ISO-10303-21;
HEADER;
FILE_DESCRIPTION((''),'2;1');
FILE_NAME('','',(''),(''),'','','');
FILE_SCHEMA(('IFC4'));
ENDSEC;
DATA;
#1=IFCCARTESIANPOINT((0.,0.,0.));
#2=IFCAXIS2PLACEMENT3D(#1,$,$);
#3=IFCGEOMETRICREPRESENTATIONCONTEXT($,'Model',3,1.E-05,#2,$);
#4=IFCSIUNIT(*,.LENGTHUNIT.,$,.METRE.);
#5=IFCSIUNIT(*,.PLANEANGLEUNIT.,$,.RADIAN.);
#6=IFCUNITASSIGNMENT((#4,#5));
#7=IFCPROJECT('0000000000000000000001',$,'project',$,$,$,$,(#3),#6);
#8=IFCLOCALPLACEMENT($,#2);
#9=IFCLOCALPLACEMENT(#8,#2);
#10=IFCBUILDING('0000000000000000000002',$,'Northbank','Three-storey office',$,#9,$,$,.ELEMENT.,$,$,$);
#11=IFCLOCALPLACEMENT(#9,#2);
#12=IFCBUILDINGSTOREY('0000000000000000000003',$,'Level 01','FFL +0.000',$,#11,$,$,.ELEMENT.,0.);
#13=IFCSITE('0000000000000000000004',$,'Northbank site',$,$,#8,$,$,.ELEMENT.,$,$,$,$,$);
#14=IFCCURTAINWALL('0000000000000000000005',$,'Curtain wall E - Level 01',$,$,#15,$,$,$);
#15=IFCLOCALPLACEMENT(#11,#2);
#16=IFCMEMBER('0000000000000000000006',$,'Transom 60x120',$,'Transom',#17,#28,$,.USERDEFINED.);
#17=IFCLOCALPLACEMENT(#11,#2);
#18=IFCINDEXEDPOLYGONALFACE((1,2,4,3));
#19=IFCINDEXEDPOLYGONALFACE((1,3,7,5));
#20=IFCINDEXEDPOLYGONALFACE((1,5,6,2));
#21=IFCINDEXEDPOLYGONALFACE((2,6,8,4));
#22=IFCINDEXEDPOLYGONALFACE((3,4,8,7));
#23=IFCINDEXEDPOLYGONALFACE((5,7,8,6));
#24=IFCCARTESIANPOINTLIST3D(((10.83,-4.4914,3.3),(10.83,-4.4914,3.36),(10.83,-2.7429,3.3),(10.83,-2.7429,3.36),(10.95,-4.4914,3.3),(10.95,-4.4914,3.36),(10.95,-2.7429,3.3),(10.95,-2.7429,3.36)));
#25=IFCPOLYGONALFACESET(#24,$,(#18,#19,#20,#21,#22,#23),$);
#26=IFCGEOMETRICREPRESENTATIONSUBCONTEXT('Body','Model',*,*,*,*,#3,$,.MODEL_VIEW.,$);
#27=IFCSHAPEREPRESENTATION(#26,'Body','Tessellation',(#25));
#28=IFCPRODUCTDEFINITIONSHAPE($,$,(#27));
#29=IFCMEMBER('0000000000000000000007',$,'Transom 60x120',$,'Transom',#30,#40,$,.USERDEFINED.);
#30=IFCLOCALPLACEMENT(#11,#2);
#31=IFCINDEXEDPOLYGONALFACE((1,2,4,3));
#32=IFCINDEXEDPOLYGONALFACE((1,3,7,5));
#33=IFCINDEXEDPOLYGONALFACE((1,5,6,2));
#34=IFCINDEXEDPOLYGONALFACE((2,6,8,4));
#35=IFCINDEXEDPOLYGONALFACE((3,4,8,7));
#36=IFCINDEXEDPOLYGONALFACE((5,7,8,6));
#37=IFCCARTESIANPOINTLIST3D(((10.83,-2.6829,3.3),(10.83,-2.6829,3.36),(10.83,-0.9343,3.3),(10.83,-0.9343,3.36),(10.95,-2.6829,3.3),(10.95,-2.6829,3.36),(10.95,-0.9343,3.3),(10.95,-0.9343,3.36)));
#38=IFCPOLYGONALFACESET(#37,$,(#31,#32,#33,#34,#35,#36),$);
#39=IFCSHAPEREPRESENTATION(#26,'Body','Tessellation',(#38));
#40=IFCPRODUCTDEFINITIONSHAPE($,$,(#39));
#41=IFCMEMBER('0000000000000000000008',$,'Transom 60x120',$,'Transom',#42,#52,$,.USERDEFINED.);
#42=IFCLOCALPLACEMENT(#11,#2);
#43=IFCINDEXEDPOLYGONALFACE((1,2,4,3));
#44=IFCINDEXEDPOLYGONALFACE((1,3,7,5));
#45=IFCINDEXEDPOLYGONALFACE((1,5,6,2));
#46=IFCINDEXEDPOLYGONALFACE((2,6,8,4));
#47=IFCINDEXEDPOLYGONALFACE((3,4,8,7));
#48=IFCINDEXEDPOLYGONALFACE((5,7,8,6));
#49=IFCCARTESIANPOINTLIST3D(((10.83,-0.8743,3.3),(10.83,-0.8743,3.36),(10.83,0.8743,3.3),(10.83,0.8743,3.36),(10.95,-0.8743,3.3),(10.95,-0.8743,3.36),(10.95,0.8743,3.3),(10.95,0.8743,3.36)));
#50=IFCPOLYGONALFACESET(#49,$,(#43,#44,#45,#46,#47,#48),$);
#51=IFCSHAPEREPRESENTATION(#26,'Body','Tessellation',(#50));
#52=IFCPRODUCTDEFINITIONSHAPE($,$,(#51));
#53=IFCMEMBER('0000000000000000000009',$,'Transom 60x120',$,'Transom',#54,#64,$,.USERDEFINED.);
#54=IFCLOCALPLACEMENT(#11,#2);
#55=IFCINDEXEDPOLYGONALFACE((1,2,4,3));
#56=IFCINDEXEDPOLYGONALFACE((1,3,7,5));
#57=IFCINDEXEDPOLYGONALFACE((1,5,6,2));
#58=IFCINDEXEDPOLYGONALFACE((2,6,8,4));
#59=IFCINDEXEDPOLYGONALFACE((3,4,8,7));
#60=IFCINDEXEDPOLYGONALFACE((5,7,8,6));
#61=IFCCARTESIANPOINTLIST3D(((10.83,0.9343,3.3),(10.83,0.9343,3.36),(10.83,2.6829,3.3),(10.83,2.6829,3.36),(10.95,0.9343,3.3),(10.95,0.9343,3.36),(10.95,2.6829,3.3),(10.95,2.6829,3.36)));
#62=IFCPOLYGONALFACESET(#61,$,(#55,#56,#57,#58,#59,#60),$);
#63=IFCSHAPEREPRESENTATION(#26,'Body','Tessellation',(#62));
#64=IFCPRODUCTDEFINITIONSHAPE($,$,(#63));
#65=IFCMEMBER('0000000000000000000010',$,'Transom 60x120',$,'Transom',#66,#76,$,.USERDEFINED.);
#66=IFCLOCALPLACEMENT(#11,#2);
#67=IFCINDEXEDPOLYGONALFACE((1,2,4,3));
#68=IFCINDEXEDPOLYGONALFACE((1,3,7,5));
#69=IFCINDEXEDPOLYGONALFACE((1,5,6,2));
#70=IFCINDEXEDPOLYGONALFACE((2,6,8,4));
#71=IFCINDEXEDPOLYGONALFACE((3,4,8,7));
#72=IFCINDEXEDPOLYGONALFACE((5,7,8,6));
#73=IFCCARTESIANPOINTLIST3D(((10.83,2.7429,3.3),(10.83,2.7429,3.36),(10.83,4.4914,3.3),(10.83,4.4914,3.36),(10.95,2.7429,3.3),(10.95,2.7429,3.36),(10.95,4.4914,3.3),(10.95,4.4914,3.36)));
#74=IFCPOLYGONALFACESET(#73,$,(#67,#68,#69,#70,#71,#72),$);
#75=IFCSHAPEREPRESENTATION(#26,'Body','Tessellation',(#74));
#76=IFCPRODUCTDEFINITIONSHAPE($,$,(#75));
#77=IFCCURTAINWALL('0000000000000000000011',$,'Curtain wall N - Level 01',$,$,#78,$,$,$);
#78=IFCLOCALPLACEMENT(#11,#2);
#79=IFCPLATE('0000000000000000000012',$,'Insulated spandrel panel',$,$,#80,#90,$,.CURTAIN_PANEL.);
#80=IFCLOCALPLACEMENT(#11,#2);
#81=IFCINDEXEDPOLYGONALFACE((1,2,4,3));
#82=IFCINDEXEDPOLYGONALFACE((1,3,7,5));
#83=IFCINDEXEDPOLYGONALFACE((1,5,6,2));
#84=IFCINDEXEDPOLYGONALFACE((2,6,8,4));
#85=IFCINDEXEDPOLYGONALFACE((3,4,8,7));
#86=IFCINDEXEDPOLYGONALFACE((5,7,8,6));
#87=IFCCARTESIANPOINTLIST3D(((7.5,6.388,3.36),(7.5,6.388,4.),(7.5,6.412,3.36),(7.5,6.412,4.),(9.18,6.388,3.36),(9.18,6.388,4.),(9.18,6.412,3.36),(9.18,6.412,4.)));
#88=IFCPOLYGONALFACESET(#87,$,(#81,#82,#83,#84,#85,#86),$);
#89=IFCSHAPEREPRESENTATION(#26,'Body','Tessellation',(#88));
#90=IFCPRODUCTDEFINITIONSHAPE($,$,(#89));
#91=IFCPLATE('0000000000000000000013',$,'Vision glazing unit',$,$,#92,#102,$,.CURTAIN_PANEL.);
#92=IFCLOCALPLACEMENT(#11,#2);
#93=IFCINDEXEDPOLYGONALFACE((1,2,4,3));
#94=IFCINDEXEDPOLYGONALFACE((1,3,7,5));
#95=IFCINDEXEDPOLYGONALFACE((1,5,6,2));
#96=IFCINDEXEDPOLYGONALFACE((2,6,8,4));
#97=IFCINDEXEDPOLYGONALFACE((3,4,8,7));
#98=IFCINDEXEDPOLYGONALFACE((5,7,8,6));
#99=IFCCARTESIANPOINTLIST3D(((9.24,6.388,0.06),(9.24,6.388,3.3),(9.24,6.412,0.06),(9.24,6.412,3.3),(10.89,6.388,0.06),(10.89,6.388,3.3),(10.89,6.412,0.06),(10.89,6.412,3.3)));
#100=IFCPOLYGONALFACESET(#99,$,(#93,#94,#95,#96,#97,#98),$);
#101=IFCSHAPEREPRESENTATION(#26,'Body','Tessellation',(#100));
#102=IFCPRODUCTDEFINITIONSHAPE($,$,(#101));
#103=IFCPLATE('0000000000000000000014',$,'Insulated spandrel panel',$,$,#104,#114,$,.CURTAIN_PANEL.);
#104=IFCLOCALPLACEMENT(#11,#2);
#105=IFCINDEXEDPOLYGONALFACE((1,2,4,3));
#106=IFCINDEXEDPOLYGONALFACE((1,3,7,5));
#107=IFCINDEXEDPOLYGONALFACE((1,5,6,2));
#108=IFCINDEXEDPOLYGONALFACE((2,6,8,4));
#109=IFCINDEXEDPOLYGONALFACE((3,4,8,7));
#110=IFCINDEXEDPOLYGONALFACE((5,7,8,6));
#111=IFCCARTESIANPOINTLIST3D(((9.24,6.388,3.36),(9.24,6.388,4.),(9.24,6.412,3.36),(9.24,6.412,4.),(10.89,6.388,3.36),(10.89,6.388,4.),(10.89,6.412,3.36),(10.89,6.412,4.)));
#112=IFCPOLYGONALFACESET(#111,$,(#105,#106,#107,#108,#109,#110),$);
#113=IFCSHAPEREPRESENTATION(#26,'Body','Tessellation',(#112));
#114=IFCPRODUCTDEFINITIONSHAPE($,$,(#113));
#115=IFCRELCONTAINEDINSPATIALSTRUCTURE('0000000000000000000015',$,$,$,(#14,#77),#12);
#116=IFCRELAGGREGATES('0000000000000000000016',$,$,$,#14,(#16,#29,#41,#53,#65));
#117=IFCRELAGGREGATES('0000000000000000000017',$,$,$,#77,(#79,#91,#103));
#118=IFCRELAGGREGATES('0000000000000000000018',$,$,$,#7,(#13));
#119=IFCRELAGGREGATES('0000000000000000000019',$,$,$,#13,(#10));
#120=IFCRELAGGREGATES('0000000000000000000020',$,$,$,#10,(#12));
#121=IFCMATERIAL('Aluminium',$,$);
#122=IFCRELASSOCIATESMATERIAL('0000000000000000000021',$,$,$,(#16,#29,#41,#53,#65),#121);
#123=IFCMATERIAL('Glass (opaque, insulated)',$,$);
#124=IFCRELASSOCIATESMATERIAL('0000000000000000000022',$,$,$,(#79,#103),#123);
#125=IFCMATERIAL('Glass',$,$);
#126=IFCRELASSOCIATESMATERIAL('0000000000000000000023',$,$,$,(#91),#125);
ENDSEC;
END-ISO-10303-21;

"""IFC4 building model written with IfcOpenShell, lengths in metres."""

from ifc_helpers import new_model, si_unit, frame, origin, place, context, subcontext, project, spatial, rectangle, extrude, material, element, aggregate, save


model = new_model("IFC4")

# Units and contexts
model_context = context("Model", 3, precision=1e-05, world=origin())
body_context = subcontext(model_context, "Body", "Model", "MODEL_VIEW")
ifc_project = project(units=[si_unit("LENGTHUNIT", "METRE"), si_unit("PLANEANGLEUNIT", "RADIAN")], contexts=[model_context])

# Site, building, storey
site_placement = place(None, origin())
site = spatial("IfcSite", under=ifc_project, at=site_placement, Name="Northbank site", CompositionType="ELEMENT")
building_placement = place(site_placement, origin())
building = spatial("IfcBuilding", under=site, at=building_placement, Name="Northbank", Description="Three-storey office", CompositionType="ELEMENT")
storey_placement = place(building_placement, origin())
storey = spatial("IfcBuildingStorey", under=building, at=storey_placement, Name="Level 01", Description="FFL +0.000", CompositionType="ELEMENT", Elevation=0.0)

# Curtain wall, members
curtain_wall_1_placement = place(storey_placement, origin())
curtain_wall_1 = element("IfcCurtainWall", 1, at=curtain_wall_1_placement, inside=storey, Name="Curtain wall E - Level 01")
ifc_material_1 = material(Name="Aluminium")
member_1_placement = place(storey_placement, origin())
member_1 = element("IfcMember", 2, at=member_1_placement, material=ifc_material_1, Name="Transom 60x120", ObjectType="Transom", PredefinedType="USERDEFINED", context=body_context, shape_type="SweptSolid", body=[
    extrude(rectangle(XDim=0.12, YDim=1.7486), frame((10.89, -3.6171, 3.3)), (0.0, 0.0, 1.0), 0.06),
])
member_2_placement = place(storey_placement, origin())
member_2 = element("IfcMember", 3, at=member_2_placement, material=ifc_material_1, Name="Transom 60x120", ObjectType="Transom", PredefinedType="USERDEFINED", context=body_context, shape_type="SweptSolid", body=[
    extrude(rectangle(XDim=0.12, YDim=1.7486), frame((10.89, -1.8086, 3.3)), (0.0, 0.0, 1.0), 0.06),
])
member_3_placement = place(storey_placement, origin())
member_3 = element("IfcMember", 4, at=member_3_placement, material=ifc_material_1, Name="Transom 60x120", ObjectType="Transom", PredefinedType="USERDEFINED", context=body_context, shape_type="SweptSolid", body=[
    extrude(rectangle(XDim=0.12, YDim=1.7486), frame((10.89, 0.0, 3.3)), (0.0, 0.0, 1.0), 0.06),
])
member_4_placement = place(storey_placement, origin())
member_4 = element("IfcMember", 5, at=member_4_placement, material=ifc_material_1, Name="Transom 60x120", ObjectType="Transom", PredefinedType="USERDEFINED", context=body_context, shape_type="SweptSolid", body=[
    extrude(rectangle(XDim=0.12, YDim=1.7486), frame((10.89, 1.8086, 3.3)), (0.0, 0.0, 1.0), 0.06),
])
member_5_placement = place(storey_placement, origin())
member_5 = element("IfcMember", 6, at=member_5_placement, material=ifc_material_1, Name="Transom 60x120", ObjectType="Transom", PredefinedType="USERDEFINED", context=body_context, shape_type="SweptSolid", body=[
    extrude(rectangle(XDim=0.12, YDim=1.7486), frame((10.89, 3.6171, 3.3)), (0.0, 0.0, 1.0), 0.06),
])
aggregate(curtain_wall_1, [member_1, member_2, member_3, member_4, member_5])

# Curtain wall, plates
curtain_wall_2_placement = place(storey_placement, origin())
curtain_wall_2 = element("IfcCurtainWall", 7, at=curtain_wall_2_placement, inside=storey, Name="Curtain wall N - Level 01")
ifc_material_2 = material(Name="Glass (opaque, insulated)")
plate_1_placement = place(storey_placement, origin())
plate_1 = element("IfcPlate", 8, at=plate_1_placement, material=ifc_material_2, Name="Insulated spandrel panel", PredefinedType="CURTAIN_PANEL", context=body_context, shape_type="SweptSolid", body=[
    extrude(rectangle(XDim=1.68, YDim=0.024), frame((8.34, 6.4, 3.36)), (0.0, 0.0, 1.0), 0.64),
])
ifc_material_3 = material(Name="Glass")
plate_2_placement = place(storey_placement, origin())
plate_2 = element("IfcPlate", 9, at=plate_2_placement, material=ifc_material_3, Name="Vision glazing unit", PredefinedType="CURTAIN_PANEL", context=body_context, shape_type="SweptSolid", body=[
    extrude(rectangle(XDim=1.65, YDim=0.024), frame((10.065, 6.4, 0.06)), (0.0, 0.0, 1.0), 3.24),
])
plate_3_placement = place(storey_placement, origin())
plate_3 = element("IfcPlate", 10, at=plate_3_placement, material=ifc_material_2, Name="Insulated spandrel panel", PredefinedType="CURTAIN_PANEL", context=body_context, shape_type="SweptSolid", body=[
    extrude(rectangle(XDim=1.65, YDim=0.024), frame((10.065, 6.4, 3.36)), (0.0, 0.0, 1.0), 0.64),
])
aggregate(curtain_wall_2, [plate_1, plate_2, plate_3])

save(model, "model.ifc")
